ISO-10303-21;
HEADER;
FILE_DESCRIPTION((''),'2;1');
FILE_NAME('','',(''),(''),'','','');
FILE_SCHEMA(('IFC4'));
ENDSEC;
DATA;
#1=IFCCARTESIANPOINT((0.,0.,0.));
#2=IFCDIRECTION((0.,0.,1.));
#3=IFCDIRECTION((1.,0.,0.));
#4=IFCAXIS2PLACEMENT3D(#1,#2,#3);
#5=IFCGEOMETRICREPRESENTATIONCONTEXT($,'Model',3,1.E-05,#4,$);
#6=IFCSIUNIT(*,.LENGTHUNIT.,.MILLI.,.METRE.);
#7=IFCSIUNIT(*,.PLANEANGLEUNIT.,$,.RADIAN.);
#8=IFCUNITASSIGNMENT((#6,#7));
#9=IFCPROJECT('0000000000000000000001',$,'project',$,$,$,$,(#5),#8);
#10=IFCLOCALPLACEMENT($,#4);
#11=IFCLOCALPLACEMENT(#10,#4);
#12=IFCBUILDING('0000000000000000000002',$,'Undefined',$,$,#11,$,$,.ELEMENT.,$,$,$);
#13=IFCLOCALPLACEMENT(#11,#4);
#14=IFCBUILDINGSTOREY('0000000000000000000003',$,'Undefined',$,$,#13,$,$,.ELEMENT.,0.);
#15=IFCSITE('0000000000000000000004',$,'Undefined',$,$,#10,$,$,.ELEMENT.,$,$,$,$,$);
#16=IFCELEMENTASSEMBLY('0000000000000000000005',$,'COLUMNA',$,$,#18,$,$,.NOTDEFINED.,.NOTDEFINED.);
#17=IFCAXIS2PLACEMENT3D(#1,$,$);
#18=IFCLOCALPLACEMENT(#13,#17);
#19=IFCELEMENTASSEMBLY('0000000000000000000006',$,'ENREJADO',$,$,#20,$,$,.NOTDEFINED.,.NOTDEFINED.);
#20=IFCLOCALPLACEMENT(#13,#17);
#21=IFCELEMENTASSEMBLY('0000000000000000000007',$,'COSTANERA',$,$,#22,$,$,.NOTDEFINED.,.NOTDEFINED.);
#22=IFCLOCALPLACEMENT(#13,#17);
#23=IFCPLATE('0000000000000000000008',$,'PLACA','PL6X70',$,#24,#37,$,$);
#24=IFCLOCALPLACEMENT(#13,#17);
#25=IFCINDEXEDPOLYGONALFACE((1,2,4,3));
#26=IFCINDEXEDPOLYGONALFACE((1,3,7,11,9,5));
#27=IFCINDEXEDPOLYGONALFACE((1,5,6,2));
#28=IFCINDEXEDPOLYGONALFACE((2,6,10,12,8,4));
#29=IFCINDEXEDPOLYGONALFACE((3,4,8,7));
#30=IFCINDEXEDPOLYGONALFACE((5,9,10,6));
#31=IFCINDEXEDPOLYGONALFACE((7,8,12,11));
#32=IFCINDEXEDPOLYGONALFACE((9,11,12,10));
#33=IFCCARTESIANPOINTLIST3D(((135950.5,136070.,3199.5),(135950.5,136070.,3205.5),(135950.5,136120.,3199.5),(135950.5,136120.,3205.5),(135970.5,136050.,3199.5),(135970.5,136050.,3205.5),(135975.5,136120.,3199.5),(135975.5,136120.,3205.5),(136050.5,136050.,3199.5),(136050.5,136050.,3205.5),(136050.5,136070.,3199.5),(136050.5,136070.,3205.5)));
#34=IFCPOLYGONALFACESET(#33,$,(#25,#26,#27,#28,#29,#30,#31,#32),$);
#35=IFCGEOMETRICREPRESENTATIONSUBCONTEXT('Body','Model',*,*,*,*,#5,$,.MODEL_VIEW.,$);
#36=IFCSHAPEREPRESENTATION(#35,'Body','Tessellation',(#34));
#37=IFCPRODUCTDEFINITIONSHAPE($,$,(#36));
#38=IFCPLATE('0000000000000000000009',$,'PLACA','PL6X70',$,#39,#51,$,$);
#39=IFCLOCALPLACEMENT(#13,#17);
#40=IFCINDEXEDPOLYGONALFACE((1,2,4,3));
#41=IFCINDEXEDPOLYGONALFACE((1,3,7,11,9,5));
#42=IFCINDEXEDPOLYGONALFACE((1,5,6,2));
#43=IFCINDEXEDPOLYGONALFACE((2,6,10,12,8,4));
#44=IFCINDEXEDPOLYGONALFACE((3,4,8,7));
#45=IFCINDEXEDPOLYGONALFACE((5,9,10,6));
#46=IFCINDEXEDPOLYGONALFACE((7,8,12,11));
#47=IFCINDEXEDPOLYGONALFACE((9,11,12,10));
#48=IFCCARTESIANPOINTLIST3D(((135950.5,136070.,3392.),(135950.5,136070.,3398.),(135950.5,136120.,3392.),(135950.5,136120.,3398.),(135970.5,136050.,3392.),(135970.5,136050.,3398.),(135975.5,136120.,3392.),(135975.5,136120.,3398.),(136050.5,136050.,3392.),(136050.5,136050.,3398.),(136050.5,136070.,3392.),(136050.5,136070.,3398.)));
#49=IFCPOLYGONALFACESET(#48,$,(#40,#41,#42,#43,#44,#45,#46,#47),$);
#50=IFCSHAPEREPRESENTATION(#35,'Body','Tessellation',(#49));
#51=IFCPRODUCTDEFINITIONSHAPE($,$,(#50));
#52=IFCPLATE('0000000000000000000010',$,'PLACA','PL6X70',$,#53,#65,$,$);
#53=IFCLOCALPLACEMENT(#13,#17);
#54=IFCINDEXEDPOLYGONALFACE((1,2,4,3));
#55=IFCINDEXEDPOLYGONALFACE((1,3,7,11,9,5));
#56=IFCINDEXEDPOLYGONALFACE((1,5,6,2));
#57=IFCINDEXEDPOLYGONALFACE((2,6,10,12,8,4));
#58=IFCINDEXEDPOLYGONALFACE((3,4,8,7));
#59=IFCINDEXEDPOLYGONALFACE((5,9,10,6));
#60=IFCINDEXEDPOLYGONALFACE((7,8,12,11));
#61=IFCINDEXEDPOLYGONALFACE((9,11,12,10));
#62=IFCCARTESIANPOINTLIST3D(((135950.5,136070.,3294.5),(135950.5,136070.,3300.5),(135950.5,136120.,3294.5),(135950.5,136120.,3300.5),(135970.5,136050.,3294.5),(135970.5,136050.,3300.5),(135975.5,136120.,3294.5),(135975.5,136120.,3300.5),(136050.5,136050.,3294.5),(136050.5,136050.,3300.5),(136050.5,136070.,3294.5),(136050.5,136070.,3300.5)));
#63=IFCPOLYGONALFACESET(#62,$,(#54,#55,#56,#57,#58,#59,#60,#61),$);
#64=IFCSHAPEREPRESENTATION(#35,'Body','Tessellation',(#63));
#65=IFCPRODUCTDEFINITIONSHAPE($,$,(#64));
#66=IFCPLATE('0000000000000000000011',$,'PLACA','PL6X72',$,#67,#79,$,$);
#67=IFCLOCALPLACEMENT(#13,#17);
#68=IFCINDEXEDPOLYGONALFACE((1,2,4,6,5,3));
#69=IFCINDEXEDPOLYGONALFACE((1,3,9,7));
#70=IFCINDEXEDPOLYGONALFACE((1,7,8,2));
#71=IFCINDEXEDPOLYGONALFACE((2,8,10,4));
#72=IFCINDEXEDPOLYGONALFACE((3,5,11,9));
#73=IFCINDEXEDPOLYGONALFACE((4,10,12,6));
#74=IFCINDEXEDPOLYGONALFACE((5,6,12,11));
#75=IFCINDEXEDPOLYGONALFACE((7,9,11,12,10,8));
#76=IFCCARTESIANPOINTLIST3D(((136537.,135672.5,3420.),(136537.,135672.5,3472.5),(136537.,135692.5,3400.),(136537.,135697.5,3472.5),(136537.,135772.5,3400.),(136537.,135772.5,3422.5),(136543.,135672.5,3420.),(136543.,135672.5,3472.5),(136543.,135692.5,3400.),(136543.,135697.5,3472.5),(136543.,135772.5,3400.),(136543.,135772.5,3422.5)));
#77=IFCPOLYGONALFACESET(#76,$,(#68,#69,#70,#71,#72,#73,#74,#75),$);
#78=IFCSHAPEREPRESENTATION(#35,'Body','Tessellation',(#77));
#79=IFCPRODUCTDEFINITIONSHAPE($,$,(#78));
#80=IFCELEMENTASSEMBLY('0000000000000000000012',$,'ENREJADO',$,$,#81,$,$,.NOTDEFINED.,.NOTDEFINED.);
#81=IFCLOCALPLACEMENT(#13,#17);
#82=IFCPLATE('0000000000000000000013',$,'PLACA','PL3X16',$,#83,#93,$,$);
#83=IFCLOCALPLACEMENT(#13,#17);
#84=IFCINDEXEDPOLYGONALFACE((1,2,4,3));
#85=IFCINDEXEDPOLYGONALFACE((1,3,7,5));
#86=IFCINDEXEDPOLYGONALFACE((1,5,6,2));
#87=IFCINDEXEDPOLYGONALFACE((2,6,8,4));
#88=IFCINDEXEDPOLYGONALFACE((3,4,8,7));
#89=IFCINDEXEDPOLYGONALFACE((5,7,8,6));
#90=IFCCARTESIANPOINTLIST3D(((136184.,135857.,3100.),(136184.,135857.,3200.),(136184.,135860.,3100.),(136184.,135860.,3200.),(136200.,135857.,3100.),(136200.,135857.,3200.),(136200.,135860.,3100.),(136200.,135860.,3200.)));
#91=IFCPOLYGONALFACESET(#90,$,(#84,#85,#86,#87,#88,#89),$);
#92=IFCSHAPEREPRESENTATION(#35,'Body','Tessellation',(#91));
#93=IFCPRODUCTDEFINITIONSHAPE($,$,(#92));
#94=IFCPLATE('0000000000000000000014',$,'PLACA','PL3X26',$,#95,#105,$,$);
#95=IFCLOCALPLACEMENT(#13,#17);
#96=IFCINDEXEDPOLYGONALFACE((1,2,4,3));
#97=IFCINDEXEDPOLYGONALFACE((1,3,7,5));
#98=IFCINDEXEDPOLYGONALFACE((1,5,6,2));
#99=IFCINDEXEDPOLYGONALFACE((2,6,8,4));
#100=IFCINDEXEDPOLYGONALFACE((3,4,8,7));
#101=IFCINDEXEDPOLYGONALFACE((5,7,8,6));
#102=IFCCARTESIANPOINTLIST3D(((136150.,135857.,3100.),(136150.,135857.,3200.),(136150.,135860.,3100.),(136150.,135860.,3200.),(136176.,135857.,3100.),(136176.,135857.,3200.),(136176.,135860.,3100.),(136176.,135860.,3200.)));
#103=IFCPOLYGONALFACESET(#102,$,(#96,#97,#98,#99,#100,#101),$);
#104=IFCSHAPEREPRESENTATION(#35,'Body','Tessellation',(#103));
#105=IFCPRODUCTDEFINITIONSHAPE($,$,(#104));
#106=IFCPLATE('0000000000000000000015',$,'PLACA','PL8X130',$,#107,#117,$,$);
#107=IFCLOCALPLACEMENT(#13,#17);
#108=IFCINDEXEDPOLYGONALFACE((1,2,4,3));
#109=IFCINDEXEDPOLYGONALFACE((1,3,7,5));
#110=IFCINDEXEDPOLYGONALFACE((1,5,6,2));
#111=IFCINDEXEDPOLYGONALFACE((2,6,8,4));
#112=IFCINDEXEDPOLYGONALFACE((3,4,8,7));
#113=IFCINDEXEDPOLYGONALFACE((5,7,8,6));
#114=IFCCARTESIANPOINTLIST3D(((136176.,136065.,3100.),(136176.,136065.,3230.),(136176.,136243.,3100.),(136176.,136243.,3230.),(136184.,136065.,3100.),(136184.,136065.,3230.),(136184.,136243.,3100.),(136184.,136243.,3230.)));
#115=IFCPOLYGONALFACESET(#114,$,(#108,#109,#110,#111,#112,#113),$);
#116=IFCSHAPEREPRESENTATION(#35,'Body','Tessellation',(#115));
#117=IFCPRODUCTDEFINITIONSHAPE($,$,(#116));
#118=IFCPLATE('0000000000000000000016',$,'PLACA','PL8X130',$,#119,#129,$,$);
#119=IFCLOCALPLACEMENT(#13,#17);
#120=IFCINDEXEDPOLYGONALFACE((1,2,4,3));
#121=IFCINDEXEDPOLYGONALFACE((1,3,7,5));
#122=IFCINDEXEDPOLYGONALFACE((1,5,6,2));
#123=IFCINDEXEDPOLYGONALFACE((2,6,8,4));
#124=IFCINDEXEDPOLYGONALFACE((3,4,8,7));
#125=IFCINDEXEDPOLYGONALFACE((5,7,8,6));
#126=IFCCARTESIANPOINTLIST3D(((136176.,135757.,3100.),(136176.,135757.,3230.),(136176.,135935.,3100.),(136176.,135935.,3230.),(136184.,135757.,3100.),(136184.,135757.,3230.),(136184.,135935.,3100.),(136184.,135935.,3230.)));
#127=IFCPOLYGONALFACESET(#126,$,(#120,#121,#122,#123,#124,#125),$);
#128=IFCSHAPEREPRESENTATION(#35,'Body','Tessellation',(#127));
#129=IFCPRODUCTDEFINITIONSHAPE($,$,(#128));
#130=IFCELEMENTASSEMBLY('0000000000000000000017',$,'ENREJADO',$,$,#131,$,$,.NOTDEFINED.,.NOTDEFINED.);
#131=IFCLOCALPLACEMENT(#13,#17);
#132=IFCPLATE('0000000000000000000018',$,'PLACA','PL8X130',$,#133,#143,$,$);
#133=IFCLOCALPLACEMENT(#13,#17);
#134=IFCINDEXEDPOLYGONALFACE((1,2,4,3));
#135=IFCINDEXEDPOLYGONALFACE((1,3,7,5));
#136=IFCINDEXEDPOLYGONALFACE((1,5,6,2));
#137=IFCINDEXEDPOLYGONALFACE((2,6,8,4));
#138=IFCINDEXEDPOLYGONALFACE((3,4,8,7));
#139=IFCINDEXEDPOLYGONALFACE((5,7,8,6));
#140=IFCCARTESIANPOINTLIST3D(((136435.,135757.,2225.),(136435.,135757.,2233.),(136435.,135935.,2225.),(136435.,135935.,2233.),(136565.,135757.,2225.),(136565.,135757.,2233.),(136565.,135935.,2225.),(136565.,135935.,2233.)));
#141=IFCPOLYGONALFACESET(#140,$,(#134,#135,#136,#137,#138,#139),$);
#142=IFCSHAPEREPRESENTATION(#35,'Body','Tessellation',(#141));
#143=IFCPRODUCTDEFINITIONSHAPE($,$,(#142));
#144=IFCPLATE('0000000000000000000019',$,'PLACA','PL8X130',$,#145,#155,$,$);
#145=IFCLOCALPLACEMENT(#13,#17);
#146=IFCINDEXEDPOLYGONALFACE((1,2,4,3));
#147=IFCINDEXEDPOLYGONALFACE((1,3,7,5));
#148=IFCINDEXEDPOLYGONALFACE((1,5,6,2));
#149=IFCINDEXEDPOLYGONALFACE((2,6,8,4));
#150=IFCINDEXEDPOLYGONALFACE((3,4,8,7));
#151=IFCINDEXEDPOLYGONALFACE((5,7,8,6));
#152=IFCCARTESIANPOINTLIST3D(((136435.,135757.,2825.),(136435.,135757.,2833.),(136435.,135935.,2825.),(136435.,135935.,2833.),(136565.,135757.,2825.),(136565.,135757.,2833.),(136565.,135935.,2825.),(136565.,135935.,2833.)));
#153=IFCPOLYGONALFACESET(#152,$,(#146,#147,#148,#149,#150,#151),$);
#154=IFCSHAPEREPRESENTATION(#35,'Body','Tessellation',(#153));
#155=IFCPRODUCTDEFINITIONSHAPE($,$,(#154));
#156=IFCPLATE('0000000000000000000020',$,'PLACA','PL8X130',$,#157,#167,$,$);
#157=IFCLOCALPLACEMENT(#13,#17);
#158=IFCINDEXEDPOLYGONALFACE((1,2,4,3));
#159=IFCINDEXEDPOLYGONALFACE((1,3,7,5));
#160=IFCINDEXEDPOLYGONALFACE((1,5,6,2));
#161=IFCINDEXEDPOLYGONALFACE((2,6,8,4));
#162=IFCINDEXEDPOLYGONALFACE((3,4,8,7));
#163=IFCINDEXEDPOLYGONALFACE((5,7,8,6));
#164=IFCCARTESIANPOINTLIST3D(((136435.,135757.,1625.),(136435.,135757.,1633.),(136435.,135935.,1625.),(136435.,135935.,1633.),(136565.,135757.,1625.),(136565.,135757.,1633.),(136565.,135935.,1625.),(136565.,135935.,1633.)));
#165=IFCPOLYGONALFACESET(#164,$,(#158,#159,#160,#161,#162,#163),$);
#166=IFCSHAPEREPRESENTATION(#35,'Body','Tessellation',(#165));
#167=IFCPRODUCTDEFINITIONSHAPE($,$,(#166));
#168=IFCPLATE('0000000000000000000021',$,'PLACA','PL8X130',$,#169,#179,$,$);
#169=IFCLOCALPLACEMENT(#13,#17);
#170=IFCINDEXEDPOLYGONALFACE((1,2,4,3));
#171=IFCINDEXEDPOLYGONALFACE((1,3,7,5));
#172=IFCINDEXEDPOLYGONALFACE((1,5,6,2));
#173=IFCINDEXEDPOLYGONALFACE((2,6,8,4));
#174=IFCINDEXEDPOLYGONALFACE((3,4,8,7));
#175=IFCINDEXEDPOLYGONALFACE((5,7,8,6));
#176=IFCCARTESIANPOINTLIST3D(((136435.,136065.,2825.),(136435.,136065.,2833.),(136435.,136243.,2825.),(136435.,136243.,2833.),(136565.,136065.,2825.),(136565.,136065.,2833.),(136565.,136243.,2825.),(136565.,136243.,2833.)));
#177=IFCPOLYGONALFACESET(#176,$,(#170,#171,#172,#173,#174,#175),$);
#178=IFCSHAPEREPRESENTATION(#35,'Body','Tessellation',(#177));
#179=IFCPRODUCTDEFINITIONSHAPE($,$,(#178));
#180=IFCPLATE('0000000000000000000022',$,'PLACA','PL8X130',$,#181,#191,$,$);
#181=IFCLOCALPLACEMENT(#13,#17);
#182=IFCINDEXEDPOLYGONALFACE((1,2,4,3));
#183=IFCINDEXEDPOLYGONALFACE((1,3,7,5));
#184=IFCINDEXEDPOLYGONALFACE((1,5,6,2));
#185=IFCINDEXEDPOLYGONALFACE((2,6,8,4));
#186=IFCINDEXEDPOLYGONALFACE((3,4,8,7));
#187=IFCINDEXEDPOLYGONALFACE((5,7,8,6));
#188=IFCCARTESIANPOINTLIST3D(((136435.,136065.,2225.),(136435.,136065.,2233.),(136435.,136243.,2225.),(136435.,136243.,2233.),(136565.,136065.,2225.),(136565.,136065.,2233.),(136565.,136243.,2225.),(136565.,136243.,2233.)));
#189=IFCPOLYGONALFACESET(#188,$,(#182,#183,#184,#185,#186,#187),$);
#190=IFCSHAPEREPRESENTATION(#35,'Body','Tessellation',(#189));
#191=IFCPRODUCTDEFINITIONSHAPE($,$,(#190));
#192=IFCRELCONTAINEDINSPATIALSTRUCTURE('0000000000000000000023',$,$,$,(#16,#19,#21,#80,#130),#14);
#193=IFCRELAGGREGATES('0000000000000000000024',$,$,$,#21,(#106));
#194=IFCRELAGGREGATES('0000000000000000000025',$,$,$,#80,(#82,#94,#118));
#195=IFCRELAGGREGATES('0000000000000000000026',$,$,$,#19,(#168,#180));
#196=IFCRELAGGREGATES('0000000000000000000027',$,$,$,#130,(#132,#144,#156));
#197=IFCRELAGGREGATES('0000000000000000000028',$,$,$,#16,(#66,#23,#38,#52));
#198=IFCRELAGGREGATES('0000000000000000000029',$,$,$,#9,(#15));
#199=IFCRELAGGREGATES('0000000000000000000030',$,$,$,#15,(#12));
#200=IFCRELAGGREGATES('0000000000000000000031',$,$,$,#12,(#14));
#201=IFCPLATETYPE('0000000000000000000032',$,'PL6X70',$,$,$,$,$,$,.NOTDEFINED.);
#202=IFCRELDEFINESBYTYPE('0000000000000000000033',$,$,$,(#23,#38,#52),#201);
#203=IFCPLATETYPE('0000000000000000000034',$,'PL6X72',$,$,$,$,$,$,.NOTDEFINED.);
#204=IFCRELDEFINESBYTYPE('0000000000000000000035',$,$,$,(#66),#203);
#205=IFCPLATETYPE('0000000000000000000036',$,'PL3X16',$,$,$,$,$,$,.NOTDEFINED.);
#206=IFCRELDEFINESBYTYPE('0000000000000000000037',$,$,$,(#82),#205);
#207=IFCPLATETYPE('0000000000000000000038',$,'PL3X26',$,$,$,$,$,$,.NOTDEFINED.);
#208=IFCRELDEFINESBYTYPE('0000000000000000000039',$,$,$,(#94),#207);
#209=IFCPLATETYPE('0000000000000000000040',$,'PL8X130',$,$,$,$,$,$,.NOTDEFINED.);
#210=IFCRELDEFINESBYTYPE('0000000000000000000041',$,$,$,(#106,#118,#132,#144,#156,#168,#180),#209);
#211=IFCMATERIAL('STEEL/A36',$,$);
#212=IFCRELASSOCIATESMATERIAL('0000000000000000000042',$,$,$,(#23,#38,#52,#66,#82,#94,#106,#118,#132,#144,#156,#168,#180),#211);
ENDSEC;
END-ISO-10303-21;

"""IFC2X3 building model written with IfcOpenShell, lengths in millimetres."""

from ifc_helpers import new_model, si_unit, frame, origin_with_axes, place, context, subcontext, project, spatial, polyline, outline, extrude, material, type_object, element, aggregate, save


model = new_model("IFC2X3")

# Units and contexts
model_context = context("Model", 3, precision=1e-05, world=origin_with_axes())
body_context = subcontext(model_context, "Body", "Model", "MODEL_VIEW")
ifc_project = project(units=[si_unit("LENGTHUNIT", "METRE", prefix="MILLI"), si_unit("PLANEANGLEUNIT", "RADIAN")], contexts=[model_context])

# Site, building, storey
site_placement = place(None, origin_with_axes())
site = spatial("IfcSite", under=ifc_project, at=site_placement, Name="Undefined", CompositionType="ELEMENT")
building_placement = place(site_placement, origin_with_axes())
building = spatial("IfcBuilding", under=site, at=building_placement, Name="Undefined", CompositionType="ELEMENT")
storey_placement = place(building_placement, origin_with_axes())
storey = spatial("IfcBuildingStorey", under=building, at=storey_placement, Name="Undefined", CompositionType="ELEMENT", Elevation=0.0)

# Element assembly
assembly_1_placement = place(storey_placement, origin_with_axes())
assembly_1 = element("IfcElementAssembly", 1, at=assembly_1_placement, inside=storey, Name="COLUMNA", AssemblyPlace="NOTDEFINED", PredefinedType="NOTDEFINED")
ifc_material_1 = material(Name="STEEL/A36")

# Element assembly
assembly_2_placement = place(storey_placement, origin_with_axes())
assembly_2 = element("IfcElementAssembly", 2, at=assembly_2_placement, inside=storey, Name="ENREJADO", AssemblyPlace="NOTDEFINED", PredefinedType="NOTDEFINED")

# Element assembly
assembly_3_placement = place(storey_placement, origin_with_axes())
assembly_3 = element("IfcElementAssembly", 3, at=assembly_3_placement, inside=storey, Name="COSTANERA", AssemblyPlace="NOTDEFINED", PredefinedType="NOTDEFINED")

# Plates
plate_type_1 = type_object("IfcPlateType", Name="PL6X70", PredefinedType="NOTDEFINED")
plate_1_placement = place(assembly_1_placement, frame((135950.5, 136120.0, 3202.5), z_axis=(0.0, 0.0, -1.0), x_axis=(1.0, 0.0, 0.0)))
plate_1 = element("IfcPlate", 4, at=plate_1_placement, type_object=plate_type_1, material=ifc_material_1, Name="PLACA", Description="PL6X70", context=body_context, shape_type="SweptSolid", body=[
    extrude(outline(polyline([(0.0, 0.0), (25.0, 0.0), (100.0, 50.0), (100.0, 70.0), (20.0, 70.0), (0.0, 50.0), (0.0, 0.0)])), frame((0.0, 0.0, -3.0), z_axis=(0.0, 0.0, 1.0), x_axis=(1.0, 0.0, 0.0)), (0.0, 0.0, 1.0), 6.0),
])
plate_2_placement = place(assembly_1_placement, frame((135950.5, 136120.0, 3395.0), z_axis=(0.0, 0.0, -1.0), x_axis=(1.0, 0.0, 0.0)))
plate_2 = element("IfcPlate", 5, at=plate_2_placement, type_object=plate_type_1, material=ifc_material_1, Name="PLACA", Description="PL6X70", context=body_context, shape_type="SweptSolid", body=[
    extrude(outline(polyline([(0.0, 0.0), (25.0, 0.0), (100.0, 50.0), (100.0, 70.0), (20.0, 70.0), (0.0, 50.0), (0.0, 0.0)])), frame((0.0, 0.0, -3.0), z_axis=(0.0, 0.0, 1.0), x_axis=(1.0, 0.0, 0.0)), (0.0, 0.0, 1.0), 6.0),
])
plate_3_placement = place(assembly_1_placement, frame((135950.5, 136120.0, 3297.5), z_axis=(0.0, 0.0, -1.0), x_axis=(1.0, 0.0, 0.0)))
plate_3 = element("IfcPlate", 6, at=plate_3_placement, type_object=plate_type_1, material=ifc_material_1, Name="PLACA", Description="PL6X70", context=body_context, shape_type="SweptSolid", body=[
    extrude(outline(polyline([(0.0, 0.0), (25.0, 0.0), (100.0, 50.0), (100.0, 70.0), (20.0, 70.0), (0.0, 50.0), (0.0, 0.0)])), frame((0.0, 0.0, -3.0), z_axis=(0.0, 0.0, 1.0), x_axis=(1.0, 0.0, 0.0)), (0.0, 0.0, 1.0), 6.0),
])
plate_type_2 = type_object("IfcPlateType", Name="PL6X72", PredefinedType="NOTDEFINED")
plate_4_placement = place(assembly_1_placement, frame((136540.0, 135672.5, 3472.5), z_axis=(-1.0, 0.0, 0.0), x_axis=(0.0, 1.0, 0.0)))
plate_4 = element("IfcPlate", 7, at=plate_4_placement, type_object=plate_type_2, material=ifc_material_1, Name="PLACA", Description="PL6X72", context=body_context, shape_type="SweptSolid", body=[
    extrude(outline(polyline([(0.0, 0.0), (25.0, 0.0), (100.0, 50.0), (100.0, 72.5), (20.0, 72.5), (0.0, 52.5), (0.0, 0.0)])), frame((0.0, 0.0, -3.0), z_axis=(0.0, 0.0, 1.0), x_axis=(1.0, 0.0, 0.0)), (0.0, 0.0, 1.0), 6.0),
])

# Element assembly, plates
assembly_4_placement = place(storey_placement, origin_with_axes())
assembly_4 = element("IfcElementAssembly", 8, at=assembly_4_placement, inside=storey, Name="ENREJADO", AssemblyPlace="NOTDEFINED", PredefinedType="NOTDEFINED")
plate_type_3 = type_object("IfcPlateType", Name="PL3X16", PredefinedType="NOTDEFINED")
plate_5_placement = place(assembly_4_placement, frame((136200.0, 135858.5, 3200.0), z_axis=(0.000001, -1.0, 0.0), x_axis=(-1.0, -0.000001, 0.0)))
plate_5 = element("IfcPlate", 9, at=plate_5_placement, type_object=plate_type_3, material=ifc_material_1, Name="PLACA", Description="PL3X16", context=body_context, shape_type="SweptSolid", body=[
    extrude(outline(polyline([(0.0, 0.0), (16.0, 0.0), (16.0, 100.0), (0.0, 100.0), (0.0, 0.0)])), frame((0.0, 0.0, -1.5), z_axis=(0.0, 0.0, 1.0), x_axis=(1.0, 0.0, 0.0)), (0.0, 0.0, 1.0), 3.0),
])
plate_type_4 = type_object("IfcPlateType", Name="PL3X26", PredefinedType="NOTDEFINED")
plate_6_placement = place(assembly_4_placement, frame((136176.0, 135858.5, 3200.0), z_axis=(0.000001, -1.0, 0.0), x_axis=(-1.0, -0.000001, 0.0)))
plate_6 = element("IfcPlate", 10, at=plate_6_placement, type_object=plate_type_4, material=ifc_material_1, Name="PLACA", Description="PL3X26", context=body_context, shape_type="SweptSolid", body=[
    extrude(outline(polyline([(0.0, 0.0), (26.0, 0.0), (26.0, 100.0), (0.0, 100.0), (0.0, 0.0)])), frame((0.0, 0.0, -1.5), z_axis=(0.0, 0.0, 1.0), x_axis=(1.0, 0.0, 0.0)), (0.0, 0.0, 1.0), 3.0),
])

# Plates
plate_type_5 = type_object("IfcPlateType", Name="PL8X130", PredefinedType="NOTDEFINED")
plate_7_placement = place(assembly_3_placement, frame((136180.0, 136065.0, 3165.0), z_axis=(-1.0, 0.000001, 0.0), x_axis=(0.000001, 1.0, 0.0)))
plate_7 = element("IfcPlate", 11, at=plate_7_placement, type_object=plate_type_5, material=ifc_material_1, Name="PLACA", Description="PL8X130", context=body_context, shape_type="SweptSolid", body=[
    extrude(outline(polyline([(0.0, -65.0), (0.0, 65.0), (178.0, 65.0), (178.0, -65.0), (0.0, -65.0)])), frame((0.0, 0.0, -4.0), z_axis=(0.0, 0.0, 1.0), x_axis=(1.0, 0.0, 0.0)), (0.0, 0.0, 1.0), 8.0),
])
aggregate(assembly_3, [plate_7])
plate_8_placement = place(assembly_4_placement, frame((136180.0, 135935.0, 3165.0), z_axis=(-1.0, -0.000001, 0.0), x_axis=(0.000001, -1.0, 0.0)))
plate_8 = element("IfcPlate", 12, at=plate_8_placement, type_object=plate_type_5, material=ifc_material_1, Name="PLACA", Description="PL8X130", context=body_context, shape_type="SweptSolid", body=[
    extrude(outline(polyline([(0.0, -65.0), (0.0, 65.0), (178.0, 65.0), (178.0, -65.0), (0.0, -65.0)])), frame((0.0, 0.0, -4.0), z_axis=(0.0, 0.0, 1.0), x_axis=(1.0, 0.0, 0.0)), (0.0, 0.0, 1.0), 8.0),
])
aggregate(assembly_4, [plate_5, plate_6, plate_8])

# Element assembly, plates
assembly_5_placement = place(storey_placement, origin_with_axes())
assembly_5 = element("IfcElementAssembly", 13, at=assembly_5_placement, inside=storey, Name="ENREJADO", AssemblyPlace="NOTDEFINED", PredefinedType="NOTDEFINED")
plate_9_placement = place(assembly_5_placement, frame((136500.0, 135935.0, 2229.0), z_axis=(0.0, 0.0, -1.0), x_axis=(0.0, -1.0, 0.0)))
plate_9 = element("IfcPlate", 14, at=plate_9_placement, type_object=plate_type_5, material=ifc_material_1, Name="PLACA", Description="PL8X130", context=body_context, shape_type="SweptSolid", body=[
    extrude(outline(polyline([(0.0, -65.0), (0.0, 65.0), (178.0, 65.0), (178.0, -65.0), (0.0, -65.0)])), frame((0.0, 0.0, -4.0), z_axis=(0.0, 0.0, 1.0), x_axis=(1.0, 0.0, 0.0)), (0.0, 0.0, 1.0), 8.0),
])
plate_10_placement = place(assembly_5_placement, frame((136500.0, 135935.0, 2829.0), z_axis=(0.0, 0.0, -1.0), x_axis=(0.0, -1.0, 0.0)))
plate_10 = element("IfcPlate", 15, at=plate_10_placement, type_object=plate_type_5, material=ifc_material_1, Name="PLACA", Description="PL8X130", context=body_context, shape_type="SweptSolid", body=[
    extrude(outline(polyline([(0.0, -65.0), (0.0, 65.0), (178.0, 65.0), (178.0, -65.0), (0.0, -65.0)])), frame((0.0, 0.0, -4.0), z_axis=(0.0, 0.0, 1.0), x_axis=(1.0, 0.0, 0.0)), (0.0, 0.0, 1.0), 8.0),
])
plate_11_placement = place(assembly_5_placement, frame((136500.0, 135935.0, 1629.0), z_axis=(0.0, 0.0, -1.0), x_axis=(0.0, -1.0, 0.0)))
plate_11 = element("IfcPlate", 16, at=plate_11_placement, type_object=plate_type_5, material=ifc_material_1, Name="PLACA", Description="PL8X130", context=body_context, shape_type="SweptSolid", body=[
    extrude(outline(polyline([(0.0, -65.0), (0.0, 65.0), (178.0, 65.0), (178.0, -65.0), (0.0, -65.0)])), frame((0.0, 0.0, -4.0), z_axis=(0.0, 0.0, 1.0), x_axis=(1.0, 0.0, 0.0)), (0.0, 0.0, 1.0), 8.0),
])

# Plates
plate_12_placement = place(assembly_2_placement, frame((136500.0, 136065.0, 2829.0), z_axis=(0.0, 0.0, -1.0), x_axis=(0.0, 1.0, 0.0)))
plate_12 = element("IfcPlate", 17, at=plate_12_placement, type_object=plate_type_5, material=ifc_material_1, Name="PLACA", Description="PL8X130", context=body_context, shape_type="SweptSolid", body=[
    extrude(outline(polyline([(0.0, -65.0), (0.0, 65.0), (178.0, 65.0), (178.0, -65.0), (0.0, -65.0)])), frame((0.0, 0.0, -4.0), z_axis=(0.0, 0.0, 1.0), x_axis=(1.0, 0.0, 0.0)), (0.0, 0.0, 1.0), 8.0),
])
plate_13_placement = place(assembly_2_placement, frame((136500.0, 136065.0, 2229.0), z_axis=(0.0, 0.0, -1.0), x_axis=(0.0, 1.0, 0.0)))
plate_13 = element("IfcPlate", 18, at=plate_13_placement, type_object=plate_type_5, material=ifc_material_1, Name="PLACA", Description="PL8X130", context=body_context, shape_type="SweptSolid", body=[
    extrude(outline(polyline([(0.0, -65.0), (0.0, 65.0), (178.0, 65.0), (178.0, -65.0), (0.0, -65.0)])), frame((0.0, 0.0, -4.0), z_axis=(0.0, 0.0, 1.0), x_axis=(1.0, 0.0, 0.0)), (0.0, 0.0, 1.0), 8.0),
])
aggregate(assembly_2, [plate_12, plate_13])
aggregate(assembly_5, [plate_9, plate_10, plate_11])

aggregate(assembly_1, [plate_4, plate_1, plate_2, plate_3])

save(model, "model.ifc")
